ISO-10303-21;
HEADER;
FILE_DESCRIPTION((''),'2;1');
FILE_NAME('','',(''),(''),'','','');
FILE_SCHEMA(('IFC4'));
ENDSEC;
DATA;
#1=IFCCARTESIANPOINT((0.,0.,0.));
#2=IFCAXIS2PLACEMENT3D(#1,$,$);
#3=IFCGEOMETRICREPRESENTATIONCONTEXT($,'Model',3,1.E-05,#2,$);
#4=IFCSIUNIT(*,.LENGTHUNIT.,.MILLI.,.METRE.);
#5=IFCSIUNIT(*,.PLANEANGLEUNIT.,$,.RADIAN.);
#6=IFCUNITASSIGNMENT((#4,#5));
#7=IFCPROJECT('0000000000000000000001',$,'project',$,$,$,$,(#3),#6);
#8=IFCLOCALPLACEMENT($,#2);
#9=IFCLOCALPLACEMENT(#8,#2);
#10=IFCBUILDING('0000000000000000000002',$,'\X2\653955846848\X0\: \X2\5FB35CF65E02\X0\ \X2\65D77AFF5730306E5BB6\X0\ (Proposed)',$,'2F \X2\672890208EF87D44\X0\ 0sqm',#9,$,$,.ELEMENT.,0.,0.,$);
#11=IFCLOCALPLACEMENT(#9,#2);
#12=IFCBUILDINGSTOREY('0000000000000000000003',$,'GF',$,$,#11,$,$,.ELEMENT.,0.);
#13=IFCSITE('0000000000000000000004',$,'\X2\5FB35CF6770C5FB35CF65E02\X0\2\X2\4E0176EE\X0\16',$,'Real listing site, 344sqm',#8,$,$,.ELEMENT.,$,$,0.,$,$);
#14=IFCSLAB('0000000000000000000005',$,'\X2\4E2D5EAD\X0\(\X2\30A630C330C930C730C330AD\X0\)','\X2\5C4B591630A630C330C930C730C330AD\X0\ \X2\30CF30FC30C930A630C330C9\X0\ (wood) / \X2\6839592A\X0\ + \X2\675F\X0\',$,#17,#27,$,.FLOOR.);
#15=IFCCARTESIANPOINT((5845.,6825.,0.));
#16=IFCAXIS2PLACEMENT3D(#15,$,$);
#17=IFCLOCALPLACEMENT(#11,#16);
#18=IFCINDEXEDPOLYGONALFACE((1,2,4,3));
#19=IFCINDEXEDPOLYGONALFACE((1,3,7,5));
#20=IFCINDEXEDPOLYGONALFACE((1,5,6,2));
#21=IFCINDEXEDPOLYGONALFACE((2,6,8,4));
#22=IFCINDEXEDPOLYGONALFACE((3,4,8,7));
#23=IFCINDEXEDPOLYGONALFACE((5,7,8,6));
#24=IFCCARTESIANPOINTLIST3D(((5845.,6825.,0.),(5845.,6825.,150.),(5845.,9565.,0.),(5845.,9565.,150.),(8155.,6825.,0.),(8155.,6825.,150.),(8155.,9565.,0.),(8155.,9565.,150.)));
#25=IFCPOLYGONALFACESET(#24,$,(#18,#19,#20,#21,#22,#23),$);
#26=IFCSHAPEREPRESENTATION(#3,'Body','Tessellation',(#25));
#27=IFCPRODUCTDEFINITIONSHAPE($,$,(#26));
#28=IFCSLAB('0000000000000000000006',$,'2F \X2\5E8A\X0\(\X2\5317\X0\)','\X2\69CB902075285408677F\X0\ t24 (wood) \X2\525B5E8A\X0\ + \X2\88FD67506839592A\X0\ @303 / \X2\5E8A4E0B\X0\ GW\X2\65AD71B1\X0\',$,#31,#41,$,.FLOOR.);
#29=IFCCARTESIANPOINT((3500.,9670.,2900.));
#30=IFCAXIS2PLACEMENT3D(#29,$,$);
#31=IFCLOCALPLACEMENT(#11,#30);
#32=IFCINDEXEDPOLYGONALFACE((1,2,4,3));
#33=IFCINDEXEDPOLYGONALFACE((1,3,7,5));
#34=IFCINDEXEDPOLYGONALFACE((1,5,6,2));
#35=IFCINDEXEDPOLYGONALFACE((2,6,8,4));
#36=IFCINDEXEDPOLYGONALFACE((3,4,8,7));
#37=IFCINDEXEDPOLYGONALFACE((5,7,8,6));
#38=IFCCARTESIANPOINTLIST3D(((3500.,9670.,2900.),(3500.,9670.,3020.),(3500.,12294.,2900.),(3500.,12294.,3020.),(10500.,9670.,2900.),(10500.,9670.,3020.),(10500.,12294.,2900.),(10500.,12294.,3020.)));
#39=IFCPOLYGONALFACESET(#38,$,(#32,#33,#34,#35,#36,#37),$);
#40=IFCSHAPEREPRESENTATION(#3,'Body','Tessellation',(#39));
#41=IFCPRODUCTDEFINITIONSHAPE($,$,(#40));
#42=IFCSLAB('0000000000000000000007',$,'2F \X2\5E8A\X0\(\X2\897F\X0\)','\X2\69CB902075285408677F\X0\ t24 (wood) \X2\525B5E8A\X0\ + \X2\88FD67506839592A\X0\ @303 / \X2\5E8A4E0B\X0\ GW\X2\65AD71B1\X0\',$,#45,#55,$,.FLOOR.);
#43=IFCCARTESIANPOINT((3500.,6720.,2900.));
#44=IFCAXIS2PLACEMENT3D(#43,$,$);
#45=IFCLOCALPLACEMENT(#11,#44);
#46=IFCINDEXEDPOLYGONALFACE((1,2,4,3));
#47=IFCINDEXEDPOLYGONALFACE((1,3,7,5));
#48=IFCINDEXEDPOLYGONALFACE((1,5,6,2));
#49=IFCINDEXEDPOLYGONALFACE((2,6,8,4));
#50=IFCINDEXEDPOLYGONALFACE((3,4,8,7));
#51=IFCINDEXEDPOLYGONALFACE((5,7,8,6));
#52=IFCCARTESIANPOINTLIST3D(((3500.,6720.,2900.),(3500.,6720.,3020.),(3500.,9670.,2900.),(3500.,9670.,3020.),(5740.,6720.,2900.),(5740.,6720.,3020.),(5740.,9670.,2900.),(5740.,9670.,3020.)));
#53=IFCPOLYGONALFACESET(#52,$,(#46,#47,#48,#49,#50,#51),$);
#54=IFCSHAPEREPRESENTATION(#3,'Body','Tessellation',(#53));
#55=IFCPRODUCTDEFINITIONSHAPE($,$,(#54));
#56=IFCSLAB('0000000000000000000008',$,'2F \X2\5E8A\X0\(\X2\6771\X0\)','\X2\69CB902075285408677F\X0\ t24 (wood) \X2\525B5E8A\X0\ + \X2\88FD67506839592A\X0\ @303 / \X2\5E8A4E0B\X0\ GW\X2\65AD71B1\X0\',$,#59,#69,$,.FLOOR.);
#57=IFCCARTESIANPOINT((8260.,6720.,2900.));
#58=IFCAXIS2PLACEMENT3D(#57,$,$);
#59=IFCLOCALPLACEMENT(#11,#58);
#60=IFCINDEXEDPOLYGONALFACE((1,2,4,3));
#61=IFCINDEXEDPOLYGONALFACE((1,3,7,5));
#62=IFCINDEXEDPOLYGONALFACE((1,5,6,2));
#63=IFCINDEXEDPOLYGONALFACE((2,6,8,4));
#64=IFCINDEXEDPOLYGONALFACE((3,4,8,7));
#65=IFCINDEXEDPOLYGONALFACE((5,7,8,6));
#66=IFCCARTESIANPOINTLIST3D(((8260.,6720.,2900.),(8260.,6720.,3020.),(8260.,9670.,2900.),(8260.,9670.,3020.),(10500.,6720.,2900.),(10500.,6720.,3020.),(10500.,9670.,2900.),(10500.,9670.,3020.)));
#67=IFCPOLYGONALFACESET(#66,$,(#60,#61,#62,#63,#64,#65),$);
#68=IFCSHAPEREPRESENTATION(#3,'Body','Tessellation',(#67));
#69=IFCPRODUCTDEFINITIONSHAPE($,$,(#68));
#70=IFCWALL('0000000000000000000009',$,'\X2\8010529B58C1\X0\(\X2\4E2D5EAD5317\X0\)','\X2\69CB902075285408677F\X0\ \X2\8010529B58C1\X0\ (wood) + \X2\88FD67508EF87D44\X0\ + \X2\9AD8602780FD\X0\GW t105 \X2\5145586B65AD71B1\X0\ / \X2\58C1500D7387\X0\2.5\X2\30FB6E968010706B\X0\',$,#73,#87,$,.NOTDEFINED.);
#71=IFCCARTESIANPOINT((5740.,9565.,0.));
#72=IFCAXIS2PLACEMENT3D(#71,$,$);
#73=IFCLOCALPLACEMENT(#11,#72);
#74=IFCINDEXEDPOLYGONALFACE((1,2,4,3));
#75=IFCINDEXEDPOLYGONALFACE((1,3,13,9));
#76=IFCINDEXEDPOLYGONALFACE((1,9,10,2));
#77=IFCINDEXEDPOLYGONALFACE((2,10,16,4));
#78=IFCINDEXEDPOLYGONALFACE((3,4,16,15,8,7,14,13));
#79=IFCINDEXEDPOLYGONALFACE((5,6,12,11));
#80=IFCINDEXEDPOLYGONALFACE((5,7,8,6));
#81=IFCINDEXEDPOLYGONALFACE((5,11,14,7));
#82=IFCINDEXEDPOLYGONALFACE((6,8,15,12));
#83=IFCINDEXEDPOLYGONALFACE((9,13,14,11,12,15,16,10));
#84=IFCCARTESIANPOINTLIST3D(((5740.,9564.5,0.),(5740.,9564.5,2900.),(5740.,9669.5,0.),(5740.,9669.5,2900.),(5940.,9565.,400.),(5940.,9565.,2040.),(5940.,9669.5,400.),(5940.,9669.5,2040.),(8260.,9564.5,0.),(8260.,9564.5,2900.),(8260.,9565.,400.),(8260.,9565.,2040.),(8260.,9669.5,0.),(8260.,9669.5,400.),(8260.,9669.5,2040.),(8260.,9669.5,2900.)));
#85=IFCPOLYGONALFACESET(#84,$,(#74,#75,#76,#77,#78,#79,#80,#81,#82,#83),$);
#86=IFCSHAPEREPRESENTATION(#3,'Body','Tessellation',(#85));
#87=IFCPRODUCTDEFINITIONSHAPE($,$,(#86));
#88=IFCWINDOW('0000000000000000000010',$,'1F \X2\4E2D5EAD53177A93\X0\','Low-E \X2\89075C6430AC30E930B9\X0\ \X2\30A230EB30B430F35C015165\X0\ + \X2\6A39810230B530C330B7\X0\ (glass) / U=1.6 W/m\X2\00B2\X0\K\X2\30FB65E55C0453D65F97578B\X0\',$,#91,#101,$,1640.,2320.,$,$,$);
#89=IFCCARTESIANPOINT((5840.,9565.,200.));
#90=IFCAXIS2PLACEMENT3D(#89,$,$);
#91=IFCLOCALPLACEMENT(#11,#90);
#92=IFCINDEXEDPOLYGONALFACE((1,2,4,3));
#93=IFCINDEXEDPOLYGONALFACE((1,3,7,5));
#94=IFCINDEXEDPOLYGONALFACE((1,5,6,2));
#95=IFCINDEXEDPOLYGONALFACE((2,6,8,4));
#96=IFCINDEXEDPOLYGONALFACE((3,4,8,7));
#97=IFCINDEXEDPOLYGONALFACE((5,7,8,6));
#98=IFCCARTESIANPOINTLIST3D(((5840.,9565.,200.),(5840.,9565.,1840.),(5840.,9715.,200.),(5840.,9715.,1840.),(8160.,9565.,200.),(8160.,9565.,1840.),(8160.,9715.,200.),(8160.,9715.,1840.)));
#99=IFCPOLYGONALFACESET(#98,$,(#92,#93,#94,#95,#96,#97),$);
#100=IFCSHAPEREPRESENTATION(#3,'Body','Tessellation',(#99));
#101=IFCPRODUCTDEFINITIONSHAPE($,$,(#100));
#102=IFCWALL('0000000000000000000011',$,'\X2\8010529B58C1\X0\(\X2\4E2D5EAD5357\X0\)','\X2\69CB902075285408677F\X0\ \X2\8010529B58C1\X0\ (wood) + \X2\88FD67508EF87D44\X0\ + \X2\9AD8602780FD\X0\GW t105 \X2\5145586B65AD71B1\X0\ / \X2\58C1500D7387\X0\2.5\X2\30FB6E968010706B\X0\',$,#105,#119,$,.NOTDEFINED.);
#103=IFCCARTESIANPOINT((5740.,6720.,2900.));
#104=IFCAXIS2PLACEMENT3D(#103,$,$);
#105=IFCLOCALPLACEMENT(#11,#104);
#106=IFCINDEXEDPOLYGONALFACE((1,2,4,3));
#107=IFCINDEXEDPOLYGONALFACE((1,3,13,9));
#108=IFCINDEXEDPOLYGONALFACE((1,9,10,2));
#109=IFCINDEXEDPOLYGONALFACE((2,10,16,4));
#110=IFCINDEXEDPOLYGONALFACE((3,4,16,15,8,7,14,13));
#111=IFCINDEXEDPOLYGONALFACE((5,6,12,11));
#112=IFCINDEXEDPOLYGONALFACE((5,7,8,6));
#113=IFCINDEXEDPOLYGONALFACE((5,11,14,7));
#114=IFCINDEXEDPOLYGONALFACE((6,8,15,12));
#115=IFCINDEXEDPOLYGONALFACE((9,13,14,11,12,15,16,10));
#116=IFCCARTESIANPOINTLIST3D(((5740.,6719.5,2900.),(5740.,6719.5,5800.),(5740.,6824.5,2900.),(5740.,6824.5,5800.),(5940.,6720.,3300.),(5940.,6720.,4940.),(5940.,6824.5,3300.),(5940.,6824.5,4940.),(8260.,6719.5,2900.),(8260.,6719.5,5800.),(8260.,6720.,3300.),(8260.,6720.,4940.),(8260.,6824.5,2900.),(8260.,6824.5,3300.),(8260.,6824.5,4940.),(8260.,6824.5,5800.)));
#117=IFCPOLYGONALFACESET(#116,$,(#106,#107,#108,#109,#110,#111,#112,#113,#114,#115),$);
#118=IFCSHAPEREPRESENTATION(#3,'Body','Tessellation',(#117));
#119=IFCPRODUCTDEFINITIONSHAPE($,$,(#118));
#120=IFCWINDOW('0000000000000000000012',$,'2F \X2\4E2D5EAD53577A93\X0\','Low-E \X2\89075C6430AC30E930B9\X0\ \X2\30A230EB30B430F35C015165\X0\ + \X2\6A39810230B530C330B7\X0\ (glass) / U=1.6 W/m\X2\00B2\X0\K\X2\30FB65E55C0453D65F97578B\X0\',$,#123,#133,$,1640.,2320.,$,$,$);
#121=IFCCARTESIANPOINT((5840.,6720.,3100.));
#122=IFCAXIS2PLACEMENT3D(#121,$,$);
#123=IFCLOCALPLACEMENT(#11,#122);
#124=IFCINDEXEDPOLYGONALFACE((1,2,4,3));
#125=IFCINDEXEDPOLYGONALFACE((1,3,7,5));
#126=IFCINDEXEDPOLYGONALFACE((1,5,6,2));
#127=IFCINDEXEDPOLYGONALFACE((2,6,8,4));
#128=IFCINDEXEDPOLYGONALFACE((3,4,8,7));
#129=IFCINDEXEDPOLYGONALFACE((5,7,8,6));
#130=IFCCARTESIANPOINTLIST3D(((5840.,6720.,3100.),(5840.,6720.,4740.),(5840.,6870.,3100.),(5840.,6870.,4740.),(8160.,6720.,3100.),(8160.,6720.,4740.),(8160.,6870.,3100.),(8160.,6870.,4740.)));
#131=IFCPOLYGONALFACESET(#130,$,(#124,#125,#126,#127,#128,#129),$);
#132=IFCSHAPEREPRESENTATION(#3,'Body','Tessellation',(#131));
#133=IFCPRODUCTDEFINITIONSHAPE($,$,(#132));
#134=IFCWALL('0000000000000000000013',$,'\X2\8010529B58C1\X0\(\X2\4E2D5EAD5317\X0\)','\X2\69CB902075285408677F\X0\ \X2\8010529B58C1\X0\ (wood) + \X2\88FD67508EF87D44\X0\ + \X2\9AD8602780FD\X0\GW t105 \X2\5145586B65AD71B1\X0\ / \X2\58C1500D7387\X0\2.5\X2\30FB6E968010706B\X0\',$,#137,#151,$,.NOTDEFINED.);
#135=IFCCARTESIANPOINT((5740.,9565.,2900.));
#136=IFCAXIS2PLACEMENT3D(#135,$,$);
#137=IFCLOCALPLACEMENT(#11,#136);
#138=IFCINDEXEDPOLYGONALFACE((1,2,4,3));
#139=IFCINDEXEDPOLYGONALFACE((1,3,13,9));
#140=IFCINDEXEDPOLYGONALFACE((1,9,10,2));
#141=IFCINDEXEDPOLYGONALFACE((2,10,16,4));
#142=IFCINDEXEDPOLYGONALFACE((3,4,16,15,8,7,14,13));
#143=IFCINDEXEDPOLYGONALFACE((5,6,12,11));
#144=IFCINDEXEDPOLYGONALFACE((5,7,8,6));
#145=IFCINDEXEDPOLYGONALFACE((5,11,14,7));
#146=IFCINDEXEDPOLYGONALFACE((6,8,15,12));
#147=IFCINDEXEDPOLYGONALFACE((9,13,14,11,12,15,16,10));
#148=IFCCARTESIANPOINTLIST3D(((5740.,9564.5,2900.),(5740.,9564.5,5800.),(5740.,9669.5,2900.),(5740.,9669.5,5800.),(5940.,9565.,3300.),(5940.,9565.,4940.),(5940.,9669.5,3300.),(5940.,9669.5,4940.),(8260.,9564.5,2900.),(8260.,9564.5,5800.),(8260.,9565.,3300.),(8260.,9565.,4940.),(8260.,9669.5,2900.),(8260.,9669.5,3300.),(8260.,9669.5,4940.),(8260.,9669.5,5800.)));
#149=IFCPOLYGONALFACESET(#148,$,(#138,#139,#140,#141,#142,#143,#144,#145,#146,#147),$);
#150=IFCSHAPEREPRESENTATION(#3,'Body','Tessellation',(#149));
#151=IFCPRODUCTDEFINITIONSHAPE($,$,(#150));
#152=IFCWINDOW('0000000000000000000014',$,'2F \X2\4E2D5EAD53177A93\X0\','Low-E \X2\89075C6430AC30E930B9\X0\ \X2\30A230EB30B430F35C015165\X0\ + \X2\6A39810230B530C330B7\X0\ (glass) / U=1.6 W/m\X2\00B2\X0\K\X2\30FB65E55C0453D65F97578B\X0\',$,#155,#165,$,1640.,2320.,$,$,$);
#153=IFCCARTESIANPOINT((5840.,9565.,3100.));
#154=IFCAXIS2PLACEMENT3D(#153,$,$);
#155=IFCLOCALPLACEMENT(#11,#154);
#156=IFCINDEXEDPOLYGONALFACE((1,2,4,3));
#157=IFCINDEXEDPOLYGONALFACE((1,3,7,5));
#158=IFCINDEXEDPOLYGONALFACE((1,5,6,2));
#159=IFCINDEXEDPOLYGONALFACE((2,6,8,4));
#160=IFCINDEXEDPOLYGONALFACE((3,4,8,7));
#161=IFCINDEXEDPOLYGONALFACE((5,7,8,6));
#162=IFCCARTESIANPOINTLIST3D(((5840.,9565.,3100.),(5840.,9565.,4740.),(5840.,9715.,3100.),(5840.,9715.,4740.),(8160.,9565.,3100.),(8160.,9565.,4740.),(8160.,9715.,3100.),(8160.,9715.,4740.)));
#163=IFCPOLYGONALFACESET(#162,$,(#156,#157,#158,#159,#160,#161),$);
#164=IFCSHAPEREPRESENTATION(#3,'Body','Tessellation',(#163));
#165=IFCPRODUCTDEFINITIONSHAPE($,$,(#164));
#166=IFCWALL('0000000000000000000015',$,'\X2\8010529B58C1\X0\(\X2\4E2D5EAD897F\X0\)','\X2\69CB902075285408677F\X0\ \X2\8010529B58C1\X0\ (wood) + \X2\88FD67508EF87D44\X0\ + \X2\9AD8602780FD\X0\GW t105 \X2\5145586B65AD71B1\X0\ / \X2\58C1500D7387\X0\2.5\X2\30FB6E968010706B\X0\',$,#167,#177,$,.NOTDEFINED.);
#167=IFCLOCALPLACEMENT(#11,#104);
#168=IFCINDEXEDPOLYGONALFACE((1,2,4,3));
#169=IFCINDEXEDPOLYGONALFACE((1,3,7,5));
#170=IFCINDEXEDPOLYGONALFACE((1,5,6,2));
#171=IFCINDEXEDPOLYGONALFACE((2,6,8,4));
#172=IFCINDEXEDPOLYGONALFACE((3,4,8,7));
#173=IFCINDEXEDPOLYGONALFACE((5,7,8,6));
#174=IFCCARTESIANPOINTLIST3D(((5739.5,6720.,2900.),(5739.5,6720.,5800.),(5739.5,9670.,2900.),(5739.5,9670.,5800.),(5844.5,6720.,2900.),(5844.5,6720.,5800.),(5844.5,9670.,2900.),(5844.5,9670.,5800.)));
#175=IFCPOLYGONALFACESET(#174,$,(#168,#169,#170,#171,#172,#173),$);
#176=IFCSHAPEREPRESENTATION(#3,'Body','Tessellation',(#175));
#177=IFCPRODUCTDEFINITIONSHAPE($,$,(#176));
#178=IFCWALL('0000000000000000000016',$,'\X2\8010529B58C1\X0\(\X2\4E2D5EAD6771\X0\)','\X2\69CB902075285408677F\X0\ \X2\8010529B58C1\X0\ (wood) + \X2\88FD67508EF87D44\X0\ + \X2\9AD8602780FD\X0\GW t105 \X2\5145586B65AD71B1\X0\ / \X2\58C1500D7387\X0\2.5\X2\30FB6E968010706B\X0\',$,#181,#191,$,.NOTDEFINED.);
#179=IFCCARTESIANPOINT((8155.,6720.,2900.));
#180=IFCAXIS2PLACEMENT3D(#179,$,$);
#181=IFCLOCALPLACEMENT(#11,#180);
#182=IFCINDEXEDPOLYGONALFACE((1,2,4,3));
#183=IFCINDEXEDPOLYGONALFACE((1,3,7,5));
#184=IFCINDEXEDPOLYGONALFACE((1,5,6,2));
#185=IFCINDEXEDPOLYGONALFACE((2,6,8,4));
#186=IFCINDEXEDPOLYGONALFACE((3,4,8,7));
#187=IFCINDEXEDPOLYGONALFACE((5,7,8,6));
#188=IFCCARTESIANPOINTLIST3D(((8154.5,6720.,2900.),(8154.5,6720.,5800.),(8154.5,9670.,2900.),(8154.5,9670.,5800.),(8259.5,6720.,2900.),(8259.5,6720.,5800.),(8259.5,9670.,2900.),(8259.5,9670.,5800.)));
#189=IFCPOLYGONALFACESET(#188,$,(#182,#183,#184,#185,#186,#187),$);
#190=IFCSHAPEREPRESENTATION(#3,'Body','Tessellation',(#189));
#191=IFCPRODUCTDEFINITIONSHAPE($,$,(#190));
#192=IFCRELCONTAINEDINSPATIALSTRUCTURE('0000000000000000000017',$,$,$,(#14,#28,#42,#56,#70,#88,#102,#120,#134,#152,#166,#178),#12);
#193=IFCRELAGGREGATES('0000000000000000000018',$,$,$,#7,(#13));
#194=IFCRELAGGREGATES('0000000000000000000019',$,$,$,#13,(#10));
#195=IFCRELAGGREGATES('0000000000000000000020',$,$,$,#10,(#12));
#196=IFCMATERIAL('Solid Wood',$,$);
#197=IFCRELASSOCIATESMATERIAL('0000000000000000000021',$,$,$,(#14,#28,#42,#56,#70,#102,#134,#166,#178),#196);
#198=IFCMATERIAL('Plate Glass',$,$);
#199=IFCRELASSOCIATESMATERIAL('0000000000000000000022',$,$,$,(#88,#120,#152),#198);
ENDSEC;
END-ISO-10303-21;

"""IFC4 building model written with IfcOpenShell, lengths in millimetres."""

from ifc_helpers import new_model, si_unit, frame, frame_2d, origin, place, context, project, spatial, rectangle, extrude, material, element, fill, save


model = new_model("IFC4")

# Units and contexts
model_context = context("Model", 3, precision=1e-05, world=origin())
ifc_project = project(units=[si_unit("LENGTHUNIT", "METRE", prefix="MILLI"), si_unit("PLANEANGLEUNIT", "RADIAN")], contexts=[model_context])

# Site, building, storey
site_placement = place(None, origin())
site = spatial("IfcSite", under=ifc_project, at=site_placement, Name="徳島県徳島市2丁目16", ObjectType="Real listing site, 344sqm", CompositionType="ELEMENT", RefElevation=0.0)
building_placement = place(site_placement, origin())
building = spatial("IfcBuilding", under=site, at=building_placement, Name="改善案: 徳島市 旗竿地の家 (Proposed)", ObjectType="2F 木造軸組 0sqm", CompositionType="ELEMENT", ElevationOfRefHeight=0.0, ElevationOfTerrain=0.0)
storey_placement = place(building_placement, origin())
storey = spatial("IfcBuildingStorey", under=building, at=storey_placement, Name="GF", CompositionType="ELEMENT", Elevation=0.0)

# Slabs
ifc_material_1 = material(Name="Solid Wood")
slab_1_placement = place(storey_placement, frame((5845.0, 6825.0, 0.0)))
element("IfcSlab", 1, at=slab_1_placement, inside=storey, material=ifc_material_1, Name="中庭(ウッドデッキ)", Description="屋外ウッドデッキ ハードウッド (wood) / 根太 + 束", PredefinedType="FLOOR", context=model_context, shape_type="SweptSolid", body=[
    extrude(rectangle(XDim=2310.0, YDim=2740.0, at=frame_2d((1155.0, 1370.0))), frame((5845.0, 6825.0, 0.0)), (0.0, 0.0, 1.0), 150.0),
])
slab_2_placement = place(storey_placement, frame((3500.0, 9670.0, 2900.0)))
element("IfcSlab", 2, at=slab_2_placement, inside=storey, material=ifc_material_1, Name="2F 床(北)", Description="構造用合板 t24 (wood) 剛床 + 製材根太 @303 / 床下 GW断熱", PredefinedType="FLOOR", context=model_context, shape_type="SweptSolid", body=[
    extrude(rectangle(XDim=7000.0, YDim=2624.0, at=frame_2d((3500.0, 1312.0))), frame((3500.0, 9670.0, 2900.0)), (0.0, 0.0, 1.0), 120.0),
])
slab_3_placement = place(storey_placement, frame((3500.0, 6720.0, 2900.0)))
element("IfcSlab", 3, at=slab_3_placement, inside=storey, material=ifc_material_1, Name="2F 床(西)", Description="構造用合板 t24 (wood) 剛床 + 製材根太 @303 / 床下 GW断熱", PredefinedType="FLOOR", context=model_context, shape_type="SweptSolid", body=[
    extrude(rectangle(XDim=2240.0, YDim=2950.0, at=frame_2d((1120.0, 1475.0))), frame((3500.0, 6720.0, 2900.0)), (0.0, 0.0, 1.0), 120.0),
])
slab_4_placement = place(storey_placement, frame((8260.0, 6720.0, 2900.0)))
element("IfcSlab", 4, at=slab_4_placement, inside=storey, material=ifc_material_1, Name="2F 床(東)", Description="構造用合板 t24 (wood) 剛床 + 製材根太 @303 / 床下 GW断熱", PredefinedType="FLOOR", context=model_context, shape_type="SweptSolid", body=[
    extrude(rectangle(XDim=2240.0, YDim=2950.0, at=frame_2d((1120.0, 1475.0))), frame((8260.0, 6720.0, 2900.0)), (0.0, 0.0, 1.0), 120.0),
])

# Wall, opening, window
wall_1_placement = place(storey_placement, frame((5740.0, 9565.0, 0.0)))
wall_1 = element("IfcWall", 5, at=wall_1_placement, inside=storey, material=ifc_material_1, Name="耐力壁(中庭北)", Description="構造用合板 耐力壁 (wood) + 製材軸組 + 高性能GW t105 充填断熱 / 壁倍率2.5・準耐火", PredefinedType="NOTDEFINED", context=model_context, shape_type="SweptSolid", body=[
    extrude(rectangle(XDim=2520.0, YDim=105.0, at=frame_2d((1260.0, 52.0))), frame((5740.0, 9565.0, 0.0)), (0.0, 0.0, 1.0), 2900.0),
])
opening_1_placement = place(storey_placement, frame((5840.0, 9565.0, 200.0)))
opening_1 = element("IfcOpeningElement", 6, at=opening_1_placement, cuts=wall_1, PredefinedType="NOTDEFINED", context=model_context, shape_type="SweptSolid", body=[
    extrude(rectangle(XDim=2320.0, YDim=150.0, at=frame_2d((1160.0, 75.0))), frame((5840.0, 9565.0, 200.0)), (0.0, 0.0, 1.0), 1640.0),
])
ifc_material_2 = material(Name="Plate Glass")
window_1_placement = place(storey_placement, frame((5840.0, 9565.0, 200.0)))
window_1 = element("IfcWindow", 7, at=window_1_placement, inside=storey, material=ifc_material_2, Name="1F 中庭北窓", Description="Low-E 複層ガラス アルゴン封入 + 樹脂サッシ (glass) / U=1.6 W/m²K・日射取得型", OverallHeight=1640.0, OverallWidth=2320.0, context=model_context, shape_type="SweptSolid", body=[
    extrude(rectangle(XDim=2320.0, YDim=150.0, at=frame_2d((1160.0, 75.0))), frame((5840.0, 9565.0, 200.0)), (0.0, 0.0, 1.0), 1640.0),
])
fill(opening_1, window_1)

# Walls, openings, windows
wall_2_placement = place(storey_placement, frame((5740.0, 6720.0, 2900.0)))
wall_2 = element("IfcWall", 8, at=wall_2_placement, inside=storey, material=ifc_material_1, Name="耐力壁(中庭南)", Description="構造用合板 耐力壁 (wood) + 製材軸組 + 高性能GW t105 充填断熱 / 壁倍率2.5・準耐火", PredefinedType="NOTDEFINED", context=model_context, shape_type="SweptSolid", body=[
    extrude(rectangle(XDim=2520.0, YDim=105.0, at=frame_2d((1260.0, 52.0))), frame((5740.0, 6720.0, 2900.0)), (0.0, 0.0, 1.0), 2900.0),
])
opening_2_placement = place(storey_placement, frame((5840.0, 6720.0, 3100.0)))
opening_2 = element("IfcOpeningElement", 9, at=opening_2_placement, cuts=wall_2, PredefinedType="NOTDEFINED", context=model_context, shape_type="SweptSolid", body=[
    extrude(rectangle(XDim=2320.0, YDim=150.0, at=frame_2d((1160.0, 75.0))), frame((5840.0, 6720.0, 3100.0)), (0.0, 0.0, 1.0), 1640.0),
])
window_2_placement = place(storey_placement, frame((5840.0, 6720.0, 3100.0)))
window_2 = element("IfcWindow", 10, at=window_2_placement, inside=storey, material=ifc_material_2, Name="2F 中庭南窓", Description="Low-E 複層ガラス アルゴン封入 + 樹脂サッシ (glass) / U=1.6 W/m²K・日射取得型", OverallHeight=1640.0, OverallWidth=2320.0, context=model_context, shape_type="SweptSolid", body=[
    extrude(rectangle(XDim=2320.0, YDim=150.0, at=frame_2d((1160.0, 75.0))), frame((5840.0, 6720.0, 3100.0)), (0.0, 0.0, 1.0), 1640.0),
])
fill(opening_2, window_2)
wall_3_placement = place(storey_placement, frame((5740.0, 9565.0, 2900.0)))
wall_3 = element("IfcWall", 11, at=wall_3_placement, inside=storey, material=ifc_material_1, Name="耐力壁(中庭北)", Description="構造用合板 耐力壁 (wood) + 製材軸組 + 高性能GW t105 充填断熱 / 壁倍率2.5・準耐火", PredefinedType="NOTDEFINED", context=model_context, shape_type="SweptSolid", body=[
    extrude(rectangle(XDim=2520.0, YDim=105.0, at=frame_2d((1260.0, 52.0))), frame((5740.0, 9565.0, 2900.0)), (0.0, 0.0, 1.0), 2900.0),
])
opening_3_placement = place(storey_placement, frame((5840.0, 9565.0, 3100.0)))
opening_3 = element("IfcOpeningElement", 12, at=opening_3_placement, cuts=wall_3, PredefinedType="NOTDEFINED", context=model_context, shape_type="SweptSolid", body=[
    extrude(rectangle(XDim=2320.0, YDim=150.0, at=frame_2d((1160.0, 75.0))), frame((5840.0, 9565.0, 3100.0)), (0.0, 0.0, 1.0), 1640.0),
])
window_3_placement = place(storey_placement, frame((5840.0, 9565.0, 3100.0)))
window_3 = element("IfcWindow", 13, at=window_3_placement, inside=storey, material=ifc_material_2, Name="2F 中庭北窓", Description="Low-E 複層ガラス アルゴン封入 + 樹脂サッシ (glass) / U=1.6 W/m²K・日射取得型", OverallHeight=1640.0, OverallWidth=2320.0, context=model_context, shape_type="SweptSolid", body=[
    extrude(rectangle(XDim=2320.0, YDim=150.0, at=frame_2d((1160.0, 75.0))), frame((5840.0, 9565.0, 3100.0)), (0.0, 0.0, 1.0), 1640.0),
])
fill(opening_3, window_3)

# Walls
wall_4_placement = place(storey_placement, frame((5740.0, 6720.0, 2900.0)))
element("IfcWall", 14, at=wall_4_placement, inside=storey, material=ifc_material_1, Name="耐力壁(中庭西)", Description="構造用合板 耐力壁 (wood) + 製材軸組 + 高性能GW t105 充填断熱 / 壁倍率2.5・準耐火", PredefinedType="NOTDEFINED", context=model_context, shape_type="SweptSolid", body=[
    extrude(rectangle(XDim=105.0, YDim=2950.0, at=frame_2d((52.0, 1475.0))), frame((5740.0, 6720.0, 2900.0)), (0.0, 0.0, 1.0), 2900.0),
])
wall_5_placement = place(storey_placement, frame((8155.0, 6720.0, 2900.0)))
element("IfcWall", 15, at=wall_5_placement, inside=storey, material=ifc_material_1, Name="耐力壁(中庭東)", Description="構造用合板 耐力壁 (wood) + 製材軸組 + 高性能GW t105 充填断熱 / 壁倍率2.5・準耐火", PredefinedType="NOTDEFINED", context=model_context, shape_type="SweptSolid", body=[
    extrude(rectangle(XDim=105.0, YDim=2950.0, at=frame_2d((52.0, 1475.0))), frame((8155.0, 6720.0, 2900.0)), (0.0, 0.0, 1.0), 2900.0),
])

save(model, "model.ifc")
